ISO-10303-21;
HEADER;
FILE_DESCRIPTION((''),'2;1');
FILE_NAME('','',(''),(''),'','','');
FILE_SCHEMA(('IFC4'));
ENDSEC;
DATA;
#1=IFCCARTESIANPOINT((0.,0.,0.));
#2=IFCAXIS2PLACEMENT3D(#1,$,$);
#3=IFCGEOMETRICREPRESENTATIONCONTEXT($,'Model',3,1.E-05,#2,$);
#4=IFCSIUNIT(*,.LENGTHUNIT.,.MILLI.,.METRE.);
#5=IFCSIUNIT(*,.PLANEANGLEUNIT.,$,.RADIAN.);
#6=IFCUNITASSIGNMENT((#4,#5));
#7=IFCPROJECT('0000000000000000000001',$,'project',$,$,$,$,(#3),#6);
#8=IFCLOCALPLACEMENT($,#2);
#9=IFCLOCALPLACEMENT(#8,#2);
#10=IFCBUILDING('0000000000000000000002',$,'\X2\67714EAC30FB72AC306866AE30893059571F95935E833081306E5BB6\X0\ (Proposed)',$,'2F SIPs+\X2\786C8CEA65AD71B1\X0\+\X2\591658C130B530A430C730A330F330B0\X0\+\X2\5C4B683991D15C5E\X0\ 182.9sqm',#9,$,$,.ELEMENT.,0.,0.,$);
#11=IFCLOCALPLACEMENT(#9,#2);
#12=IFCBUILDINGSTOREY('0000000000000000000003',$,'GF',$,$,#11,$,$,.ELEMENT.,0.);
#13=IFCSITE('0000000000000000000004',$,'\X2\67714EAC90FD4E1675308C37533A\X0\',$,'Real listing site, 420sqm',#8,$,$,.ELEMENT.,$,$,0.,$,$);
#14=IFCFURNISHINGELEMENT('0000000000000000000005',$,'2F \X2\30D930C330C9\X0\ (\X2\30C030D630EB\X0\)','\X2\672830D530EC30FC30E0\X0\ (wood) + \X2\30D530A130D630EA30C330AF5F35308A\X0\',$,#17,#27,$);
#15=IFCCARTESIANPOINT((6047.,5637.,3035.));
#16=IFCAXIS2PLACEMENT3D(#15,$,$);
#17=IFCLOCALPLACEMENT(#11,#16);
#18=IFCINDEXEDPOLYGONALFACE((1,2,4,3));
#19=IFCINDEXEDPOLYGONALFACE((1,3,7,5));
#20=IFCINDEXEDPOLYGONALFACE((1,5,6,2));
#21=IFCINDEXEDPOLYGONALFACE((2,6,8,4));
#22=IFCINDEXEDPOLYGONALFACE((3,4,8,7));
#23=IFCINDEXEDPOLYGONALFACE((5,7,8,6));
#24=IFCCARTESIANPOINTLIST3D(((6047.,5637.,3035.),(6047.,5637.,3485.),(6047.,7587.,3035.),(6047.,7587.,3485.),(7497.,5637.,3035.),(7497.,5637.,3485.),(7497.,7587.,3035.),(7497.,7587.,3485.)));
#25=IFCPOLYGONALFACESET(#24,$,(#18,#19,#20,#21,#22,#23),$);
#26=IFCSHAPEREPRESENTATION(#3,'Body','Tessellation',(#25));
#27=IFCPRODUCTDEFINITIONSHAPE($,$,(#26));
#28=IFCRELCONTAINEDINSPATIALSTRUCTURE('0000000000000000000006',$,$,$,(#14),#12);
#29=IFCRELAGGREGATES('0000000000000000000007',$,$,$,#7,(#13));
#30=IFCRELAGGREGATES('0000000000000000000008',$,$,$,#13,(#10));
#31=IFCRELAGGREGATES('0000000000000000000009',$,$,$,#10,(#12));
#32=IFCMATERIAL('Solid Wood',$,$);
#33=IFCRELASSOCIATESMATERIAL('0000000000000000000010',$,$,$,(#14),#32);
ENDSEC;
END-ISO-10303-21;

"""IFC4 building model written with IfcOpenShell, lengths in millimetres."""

from ifc_helpers import new_model, si_unit, frame, frame_2d, origin, place, context, project, spatial, rectangle, extrude, material, element, save


model = new_model("IFC4")

# Units and contexts
model_context = context("Model", 3, precision=1e-05, world=origin())
ifc_project = project(units=[si_unit("LENGTHUNIT", "METRE", prefix="MILLI"), si_unit("PLANEANGLEUNIT", "RADIAN")], contexts=[model_context])

# Site, building, storey
site_placement = place(None, origin())
site = spatial("IfcSite", under=ifc_project, at=site_placement, Name="東京都世田谷区", ObjectType="Real listing site, 420sqm", CompositionType="ELEMENT", RefElevation=0.0)
building_placement = place(site_placement, origin())
building = spatial("IfcBuilding", under=site, at=building_placement, Name="東京・犬と暮らす土間広めの家 (Proposed)", ObjectType="2F SIPs+硬質断熱+外壁サイディング+屋根金属 182.9sqm", CompositionType="ELEMENT", ElevationOfRefHeight=0.0, ElevationOfTerrain=0.0)
storey_placement = place(building_placement, origin())
storey = spatial("IfcBuildingStorey", under=building, at=storey_placement, Name="GF", CompositionType="ELEMENT", Elevation=0.0)

# Shared definitions
ifc_material_1 = material(Name="Solid Wood")

# Furnishing element
furnishing_1_placement = place(storey_placement, frame((6047.0, 5637.0, 3035.0)))
element("IfcFurnishingElement", 1, at=furnishing_1_placement, inside=storey, material=ifc_material_1, Name="2F ベッド (ダブル)", Description="木フレーム (wood) + ファブリック張り", context=model_context, shape_type="SweptSolid", body=[
    extrude(rectangle(XDim=1450.0, YDim=1950.0, at=frame_2d((725.0, 975.0))), frame((6047.0, 5637.0, 3035.0)), (0.0, 0.0, 1.0), 450.0),
])

save(model, "model.ifc")
